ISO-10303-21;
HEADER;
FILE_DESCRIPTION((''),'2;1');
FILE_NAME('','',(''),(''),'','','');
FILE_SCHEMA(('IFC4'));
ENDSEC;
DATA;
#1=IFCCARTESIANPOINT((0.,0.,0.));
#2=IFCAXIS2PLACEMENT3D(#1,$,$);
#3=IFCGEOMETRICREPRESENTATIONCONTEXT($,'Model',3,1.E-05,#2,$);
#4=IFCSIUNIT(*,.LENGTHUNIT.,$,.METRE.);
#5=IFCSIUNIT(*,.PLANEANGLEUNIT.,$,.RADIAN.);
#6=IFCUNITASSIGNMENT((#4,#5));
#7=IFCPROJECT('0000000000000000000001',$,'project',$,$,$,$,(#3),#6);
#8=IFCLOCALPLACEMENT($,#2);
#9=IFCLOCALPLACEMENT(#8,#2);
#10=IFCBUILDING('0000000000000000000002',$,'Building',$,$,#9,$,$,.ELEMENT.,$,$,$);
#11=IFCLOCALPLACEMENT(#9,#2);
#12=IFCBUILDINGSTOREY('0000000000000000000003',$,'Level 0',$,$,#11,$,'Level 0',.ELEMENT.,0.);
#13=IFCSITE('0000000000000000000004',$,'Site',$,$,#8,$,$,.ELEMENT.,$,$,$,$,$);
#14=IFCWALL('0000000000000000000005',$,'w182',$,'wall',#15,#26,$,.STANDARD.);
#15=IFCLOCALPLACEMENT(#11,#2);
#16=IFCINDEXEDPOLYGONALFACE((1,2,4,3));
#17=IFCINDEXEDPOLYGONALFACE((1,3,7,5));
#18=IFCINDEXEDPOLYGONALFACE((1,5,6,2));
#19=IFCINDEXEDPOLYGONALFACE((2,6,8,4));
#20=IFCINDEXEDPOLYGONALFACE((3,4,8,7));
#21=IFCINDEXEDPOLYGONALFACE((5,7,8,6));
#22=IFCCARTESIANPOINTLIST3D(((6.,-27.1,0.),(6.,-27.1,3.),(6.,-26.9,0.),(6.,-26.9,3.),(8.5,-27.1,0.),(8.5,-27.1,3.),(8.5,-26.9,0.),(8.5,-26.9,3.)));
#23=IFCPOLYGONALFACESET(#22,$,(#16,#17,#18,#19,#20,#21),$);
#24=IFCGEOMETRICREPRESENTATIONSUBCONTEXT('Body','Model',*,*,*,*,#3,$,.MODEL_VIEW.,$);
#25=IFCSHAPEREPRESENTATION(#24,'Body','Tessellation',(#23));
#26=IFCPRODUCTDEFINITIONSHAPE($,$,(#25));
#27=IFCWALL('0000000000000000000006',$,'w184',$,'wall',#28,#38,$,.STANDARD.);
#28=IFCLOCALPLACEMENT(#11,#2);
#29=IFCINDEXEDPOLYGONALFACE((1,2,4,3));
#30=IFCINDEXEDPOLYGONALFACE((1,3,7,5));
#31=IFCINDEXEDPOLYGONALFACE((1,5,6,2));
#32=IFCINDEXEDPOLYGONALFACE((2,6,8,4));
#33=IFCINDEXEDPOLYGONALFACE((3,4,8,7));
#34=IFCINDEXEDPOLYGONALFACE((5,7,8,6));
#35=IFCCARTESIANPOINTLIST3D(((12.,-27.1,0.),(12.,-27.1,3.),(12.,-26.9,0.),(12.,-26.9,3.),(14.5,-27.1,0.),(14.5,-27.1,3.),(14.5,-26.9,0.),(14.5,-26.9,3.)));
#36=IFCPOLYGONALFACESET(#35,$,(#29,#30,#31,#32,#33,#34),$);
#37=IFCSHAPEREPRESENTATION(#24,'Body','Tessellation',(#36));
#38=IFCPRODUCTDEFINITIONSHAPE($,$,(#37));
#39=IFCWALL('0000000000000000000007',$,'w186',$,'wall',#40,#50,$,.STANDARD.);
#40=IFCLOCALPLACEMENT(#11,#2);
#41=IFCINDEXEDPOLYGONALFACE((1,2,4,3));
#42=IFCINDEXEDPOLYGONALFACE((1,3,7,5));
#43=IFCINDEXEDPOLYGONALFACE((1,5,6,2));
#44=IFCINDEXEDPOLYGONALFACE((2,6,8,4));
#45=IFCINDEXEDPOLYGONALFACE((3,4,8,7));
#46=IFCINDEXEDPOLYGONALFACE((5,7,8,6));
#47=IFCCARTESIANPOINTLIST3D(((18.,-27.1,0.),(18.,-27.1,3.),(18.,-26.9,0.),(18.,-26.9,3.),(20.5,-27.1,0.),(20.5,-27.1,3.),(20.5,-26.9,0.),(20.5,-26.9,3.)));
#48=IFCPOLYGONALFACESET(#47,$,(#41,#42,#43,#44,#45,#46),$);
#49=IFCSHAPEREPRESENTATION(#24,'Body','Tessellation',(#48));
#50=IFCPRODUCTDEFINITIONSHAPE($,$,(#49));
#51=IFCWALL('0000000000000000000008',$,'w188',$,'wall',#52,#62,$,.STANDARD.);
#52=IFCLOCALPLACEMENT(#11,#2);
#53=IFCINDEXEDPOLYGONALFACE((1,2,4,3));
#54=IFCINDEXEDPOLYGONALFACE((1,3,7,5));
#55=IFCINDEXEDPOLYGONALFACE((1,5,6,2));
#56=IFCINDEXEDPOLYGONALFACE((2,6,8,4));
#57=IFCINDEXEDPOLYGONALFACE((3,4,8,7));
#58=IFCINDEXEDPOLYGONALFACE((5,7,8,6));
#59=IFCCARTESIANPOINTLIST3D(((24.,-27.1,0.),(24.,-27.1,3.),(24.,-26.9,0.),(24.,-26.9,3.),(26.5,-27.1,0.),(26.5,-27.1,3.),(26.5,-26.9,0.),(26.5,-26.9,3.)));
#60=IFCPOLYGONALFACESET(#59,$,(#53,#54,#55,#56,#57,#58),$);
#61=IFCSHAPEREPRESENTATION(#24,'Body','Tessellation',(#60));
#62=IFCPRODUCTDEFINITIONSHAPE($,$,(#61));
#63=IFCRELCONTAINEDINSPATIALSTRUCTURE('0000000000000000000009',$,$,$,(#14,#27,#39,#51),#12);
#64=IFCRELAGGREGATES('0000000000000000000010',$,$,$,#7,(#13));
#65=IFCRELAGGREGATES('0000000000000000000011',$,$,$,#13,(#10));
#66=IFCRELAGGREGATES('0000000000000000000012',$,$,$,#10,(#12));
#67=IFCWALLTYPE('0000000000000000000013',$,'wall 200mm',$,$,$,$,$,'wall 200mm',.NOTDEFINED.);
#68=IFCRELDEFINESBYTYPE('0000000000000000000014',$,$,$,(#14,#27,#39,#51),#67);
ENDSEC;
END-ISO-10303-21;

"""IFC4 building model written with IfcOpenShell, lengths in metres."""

from ifc_helpers import new_model, si_unit, frame, frame_2d, origin, place, context, subcontext, project, spatial, rectangle, extrude, type_object, element, save


model = new_model("IFC4")

# Units and contexts
model_context = context("Model", 3, precision=1e-05, world=origin())
body_context = subcontext(model_context, "Body", "Model", "MODEL_VIEW")
ifc_project = project(units=[si_unit("LENGTHUNIT", "METRE"), si_unit("PLANEANGLEUNIT", "RADIAN")], contexts=[model_context])

# Site, building, storey
site_placement = place(None, origin())
site = spatial("IfcSite", under=ifc_project, at=site_placement, Name="Site", CompositionType="ELEMENT")
building_placement = place(site_placement, origin())
building = spatial("IfcBuilding", under=site, at=building_placement, Name="Building", CompositionType="ELEMENT")
storey_placement = place(building_placement, origin())
storey = spatial("IfcBuildingStorey", under=building, at=storey_placement, Name="Level 0", LongName="Level 0", CompositionType="ELEMENT", Elevation=0.0)

# Walls
wall_type = type_object("IfcWallType", Name="wall 200mm", ElementType="wall 200mm", PredefinedType="NOTDEFINED")
for number, where, z_axis, x_axis, name in (
    (1, (6.0, -27.0, 0.0), (0.0, 0.0, 1.0), (1.0, 0.0, 0.0), "w182"),
    (2, (12.0, -27.0, 0.0), (0.0, 0.0, 1.0), (1.0, 0.0, 0.0), "w184"),
    (3, (18.0, -27.0, 0.0), (0.0, 0.0, 1.0), (1.0, 0.0, 0.0), "w186"),
    (4, (24.0, -27.0, 0.0), (0.0, 0.0, 1.0), (1.0, 0.0, 0.0), "w188"),
):
    element("IfcWall", number, at=place(storey_placement, frame(where, z_axis=z_axis, x_axis=x_axis)), inside=storey, type_object=wall_type, Name=name, ObjectType="wall", PredefinedType="STANDARD", context=body_context, shape_type="SweptSolid", body=[
        extrude(rectangle(XDim=2.5, YDim=0.2, at=frame_2d((1.25, 0.0))), origin(), (0.0, 0.0, 1.0), 3.0),
    ])

save(model, "model.ifc")
